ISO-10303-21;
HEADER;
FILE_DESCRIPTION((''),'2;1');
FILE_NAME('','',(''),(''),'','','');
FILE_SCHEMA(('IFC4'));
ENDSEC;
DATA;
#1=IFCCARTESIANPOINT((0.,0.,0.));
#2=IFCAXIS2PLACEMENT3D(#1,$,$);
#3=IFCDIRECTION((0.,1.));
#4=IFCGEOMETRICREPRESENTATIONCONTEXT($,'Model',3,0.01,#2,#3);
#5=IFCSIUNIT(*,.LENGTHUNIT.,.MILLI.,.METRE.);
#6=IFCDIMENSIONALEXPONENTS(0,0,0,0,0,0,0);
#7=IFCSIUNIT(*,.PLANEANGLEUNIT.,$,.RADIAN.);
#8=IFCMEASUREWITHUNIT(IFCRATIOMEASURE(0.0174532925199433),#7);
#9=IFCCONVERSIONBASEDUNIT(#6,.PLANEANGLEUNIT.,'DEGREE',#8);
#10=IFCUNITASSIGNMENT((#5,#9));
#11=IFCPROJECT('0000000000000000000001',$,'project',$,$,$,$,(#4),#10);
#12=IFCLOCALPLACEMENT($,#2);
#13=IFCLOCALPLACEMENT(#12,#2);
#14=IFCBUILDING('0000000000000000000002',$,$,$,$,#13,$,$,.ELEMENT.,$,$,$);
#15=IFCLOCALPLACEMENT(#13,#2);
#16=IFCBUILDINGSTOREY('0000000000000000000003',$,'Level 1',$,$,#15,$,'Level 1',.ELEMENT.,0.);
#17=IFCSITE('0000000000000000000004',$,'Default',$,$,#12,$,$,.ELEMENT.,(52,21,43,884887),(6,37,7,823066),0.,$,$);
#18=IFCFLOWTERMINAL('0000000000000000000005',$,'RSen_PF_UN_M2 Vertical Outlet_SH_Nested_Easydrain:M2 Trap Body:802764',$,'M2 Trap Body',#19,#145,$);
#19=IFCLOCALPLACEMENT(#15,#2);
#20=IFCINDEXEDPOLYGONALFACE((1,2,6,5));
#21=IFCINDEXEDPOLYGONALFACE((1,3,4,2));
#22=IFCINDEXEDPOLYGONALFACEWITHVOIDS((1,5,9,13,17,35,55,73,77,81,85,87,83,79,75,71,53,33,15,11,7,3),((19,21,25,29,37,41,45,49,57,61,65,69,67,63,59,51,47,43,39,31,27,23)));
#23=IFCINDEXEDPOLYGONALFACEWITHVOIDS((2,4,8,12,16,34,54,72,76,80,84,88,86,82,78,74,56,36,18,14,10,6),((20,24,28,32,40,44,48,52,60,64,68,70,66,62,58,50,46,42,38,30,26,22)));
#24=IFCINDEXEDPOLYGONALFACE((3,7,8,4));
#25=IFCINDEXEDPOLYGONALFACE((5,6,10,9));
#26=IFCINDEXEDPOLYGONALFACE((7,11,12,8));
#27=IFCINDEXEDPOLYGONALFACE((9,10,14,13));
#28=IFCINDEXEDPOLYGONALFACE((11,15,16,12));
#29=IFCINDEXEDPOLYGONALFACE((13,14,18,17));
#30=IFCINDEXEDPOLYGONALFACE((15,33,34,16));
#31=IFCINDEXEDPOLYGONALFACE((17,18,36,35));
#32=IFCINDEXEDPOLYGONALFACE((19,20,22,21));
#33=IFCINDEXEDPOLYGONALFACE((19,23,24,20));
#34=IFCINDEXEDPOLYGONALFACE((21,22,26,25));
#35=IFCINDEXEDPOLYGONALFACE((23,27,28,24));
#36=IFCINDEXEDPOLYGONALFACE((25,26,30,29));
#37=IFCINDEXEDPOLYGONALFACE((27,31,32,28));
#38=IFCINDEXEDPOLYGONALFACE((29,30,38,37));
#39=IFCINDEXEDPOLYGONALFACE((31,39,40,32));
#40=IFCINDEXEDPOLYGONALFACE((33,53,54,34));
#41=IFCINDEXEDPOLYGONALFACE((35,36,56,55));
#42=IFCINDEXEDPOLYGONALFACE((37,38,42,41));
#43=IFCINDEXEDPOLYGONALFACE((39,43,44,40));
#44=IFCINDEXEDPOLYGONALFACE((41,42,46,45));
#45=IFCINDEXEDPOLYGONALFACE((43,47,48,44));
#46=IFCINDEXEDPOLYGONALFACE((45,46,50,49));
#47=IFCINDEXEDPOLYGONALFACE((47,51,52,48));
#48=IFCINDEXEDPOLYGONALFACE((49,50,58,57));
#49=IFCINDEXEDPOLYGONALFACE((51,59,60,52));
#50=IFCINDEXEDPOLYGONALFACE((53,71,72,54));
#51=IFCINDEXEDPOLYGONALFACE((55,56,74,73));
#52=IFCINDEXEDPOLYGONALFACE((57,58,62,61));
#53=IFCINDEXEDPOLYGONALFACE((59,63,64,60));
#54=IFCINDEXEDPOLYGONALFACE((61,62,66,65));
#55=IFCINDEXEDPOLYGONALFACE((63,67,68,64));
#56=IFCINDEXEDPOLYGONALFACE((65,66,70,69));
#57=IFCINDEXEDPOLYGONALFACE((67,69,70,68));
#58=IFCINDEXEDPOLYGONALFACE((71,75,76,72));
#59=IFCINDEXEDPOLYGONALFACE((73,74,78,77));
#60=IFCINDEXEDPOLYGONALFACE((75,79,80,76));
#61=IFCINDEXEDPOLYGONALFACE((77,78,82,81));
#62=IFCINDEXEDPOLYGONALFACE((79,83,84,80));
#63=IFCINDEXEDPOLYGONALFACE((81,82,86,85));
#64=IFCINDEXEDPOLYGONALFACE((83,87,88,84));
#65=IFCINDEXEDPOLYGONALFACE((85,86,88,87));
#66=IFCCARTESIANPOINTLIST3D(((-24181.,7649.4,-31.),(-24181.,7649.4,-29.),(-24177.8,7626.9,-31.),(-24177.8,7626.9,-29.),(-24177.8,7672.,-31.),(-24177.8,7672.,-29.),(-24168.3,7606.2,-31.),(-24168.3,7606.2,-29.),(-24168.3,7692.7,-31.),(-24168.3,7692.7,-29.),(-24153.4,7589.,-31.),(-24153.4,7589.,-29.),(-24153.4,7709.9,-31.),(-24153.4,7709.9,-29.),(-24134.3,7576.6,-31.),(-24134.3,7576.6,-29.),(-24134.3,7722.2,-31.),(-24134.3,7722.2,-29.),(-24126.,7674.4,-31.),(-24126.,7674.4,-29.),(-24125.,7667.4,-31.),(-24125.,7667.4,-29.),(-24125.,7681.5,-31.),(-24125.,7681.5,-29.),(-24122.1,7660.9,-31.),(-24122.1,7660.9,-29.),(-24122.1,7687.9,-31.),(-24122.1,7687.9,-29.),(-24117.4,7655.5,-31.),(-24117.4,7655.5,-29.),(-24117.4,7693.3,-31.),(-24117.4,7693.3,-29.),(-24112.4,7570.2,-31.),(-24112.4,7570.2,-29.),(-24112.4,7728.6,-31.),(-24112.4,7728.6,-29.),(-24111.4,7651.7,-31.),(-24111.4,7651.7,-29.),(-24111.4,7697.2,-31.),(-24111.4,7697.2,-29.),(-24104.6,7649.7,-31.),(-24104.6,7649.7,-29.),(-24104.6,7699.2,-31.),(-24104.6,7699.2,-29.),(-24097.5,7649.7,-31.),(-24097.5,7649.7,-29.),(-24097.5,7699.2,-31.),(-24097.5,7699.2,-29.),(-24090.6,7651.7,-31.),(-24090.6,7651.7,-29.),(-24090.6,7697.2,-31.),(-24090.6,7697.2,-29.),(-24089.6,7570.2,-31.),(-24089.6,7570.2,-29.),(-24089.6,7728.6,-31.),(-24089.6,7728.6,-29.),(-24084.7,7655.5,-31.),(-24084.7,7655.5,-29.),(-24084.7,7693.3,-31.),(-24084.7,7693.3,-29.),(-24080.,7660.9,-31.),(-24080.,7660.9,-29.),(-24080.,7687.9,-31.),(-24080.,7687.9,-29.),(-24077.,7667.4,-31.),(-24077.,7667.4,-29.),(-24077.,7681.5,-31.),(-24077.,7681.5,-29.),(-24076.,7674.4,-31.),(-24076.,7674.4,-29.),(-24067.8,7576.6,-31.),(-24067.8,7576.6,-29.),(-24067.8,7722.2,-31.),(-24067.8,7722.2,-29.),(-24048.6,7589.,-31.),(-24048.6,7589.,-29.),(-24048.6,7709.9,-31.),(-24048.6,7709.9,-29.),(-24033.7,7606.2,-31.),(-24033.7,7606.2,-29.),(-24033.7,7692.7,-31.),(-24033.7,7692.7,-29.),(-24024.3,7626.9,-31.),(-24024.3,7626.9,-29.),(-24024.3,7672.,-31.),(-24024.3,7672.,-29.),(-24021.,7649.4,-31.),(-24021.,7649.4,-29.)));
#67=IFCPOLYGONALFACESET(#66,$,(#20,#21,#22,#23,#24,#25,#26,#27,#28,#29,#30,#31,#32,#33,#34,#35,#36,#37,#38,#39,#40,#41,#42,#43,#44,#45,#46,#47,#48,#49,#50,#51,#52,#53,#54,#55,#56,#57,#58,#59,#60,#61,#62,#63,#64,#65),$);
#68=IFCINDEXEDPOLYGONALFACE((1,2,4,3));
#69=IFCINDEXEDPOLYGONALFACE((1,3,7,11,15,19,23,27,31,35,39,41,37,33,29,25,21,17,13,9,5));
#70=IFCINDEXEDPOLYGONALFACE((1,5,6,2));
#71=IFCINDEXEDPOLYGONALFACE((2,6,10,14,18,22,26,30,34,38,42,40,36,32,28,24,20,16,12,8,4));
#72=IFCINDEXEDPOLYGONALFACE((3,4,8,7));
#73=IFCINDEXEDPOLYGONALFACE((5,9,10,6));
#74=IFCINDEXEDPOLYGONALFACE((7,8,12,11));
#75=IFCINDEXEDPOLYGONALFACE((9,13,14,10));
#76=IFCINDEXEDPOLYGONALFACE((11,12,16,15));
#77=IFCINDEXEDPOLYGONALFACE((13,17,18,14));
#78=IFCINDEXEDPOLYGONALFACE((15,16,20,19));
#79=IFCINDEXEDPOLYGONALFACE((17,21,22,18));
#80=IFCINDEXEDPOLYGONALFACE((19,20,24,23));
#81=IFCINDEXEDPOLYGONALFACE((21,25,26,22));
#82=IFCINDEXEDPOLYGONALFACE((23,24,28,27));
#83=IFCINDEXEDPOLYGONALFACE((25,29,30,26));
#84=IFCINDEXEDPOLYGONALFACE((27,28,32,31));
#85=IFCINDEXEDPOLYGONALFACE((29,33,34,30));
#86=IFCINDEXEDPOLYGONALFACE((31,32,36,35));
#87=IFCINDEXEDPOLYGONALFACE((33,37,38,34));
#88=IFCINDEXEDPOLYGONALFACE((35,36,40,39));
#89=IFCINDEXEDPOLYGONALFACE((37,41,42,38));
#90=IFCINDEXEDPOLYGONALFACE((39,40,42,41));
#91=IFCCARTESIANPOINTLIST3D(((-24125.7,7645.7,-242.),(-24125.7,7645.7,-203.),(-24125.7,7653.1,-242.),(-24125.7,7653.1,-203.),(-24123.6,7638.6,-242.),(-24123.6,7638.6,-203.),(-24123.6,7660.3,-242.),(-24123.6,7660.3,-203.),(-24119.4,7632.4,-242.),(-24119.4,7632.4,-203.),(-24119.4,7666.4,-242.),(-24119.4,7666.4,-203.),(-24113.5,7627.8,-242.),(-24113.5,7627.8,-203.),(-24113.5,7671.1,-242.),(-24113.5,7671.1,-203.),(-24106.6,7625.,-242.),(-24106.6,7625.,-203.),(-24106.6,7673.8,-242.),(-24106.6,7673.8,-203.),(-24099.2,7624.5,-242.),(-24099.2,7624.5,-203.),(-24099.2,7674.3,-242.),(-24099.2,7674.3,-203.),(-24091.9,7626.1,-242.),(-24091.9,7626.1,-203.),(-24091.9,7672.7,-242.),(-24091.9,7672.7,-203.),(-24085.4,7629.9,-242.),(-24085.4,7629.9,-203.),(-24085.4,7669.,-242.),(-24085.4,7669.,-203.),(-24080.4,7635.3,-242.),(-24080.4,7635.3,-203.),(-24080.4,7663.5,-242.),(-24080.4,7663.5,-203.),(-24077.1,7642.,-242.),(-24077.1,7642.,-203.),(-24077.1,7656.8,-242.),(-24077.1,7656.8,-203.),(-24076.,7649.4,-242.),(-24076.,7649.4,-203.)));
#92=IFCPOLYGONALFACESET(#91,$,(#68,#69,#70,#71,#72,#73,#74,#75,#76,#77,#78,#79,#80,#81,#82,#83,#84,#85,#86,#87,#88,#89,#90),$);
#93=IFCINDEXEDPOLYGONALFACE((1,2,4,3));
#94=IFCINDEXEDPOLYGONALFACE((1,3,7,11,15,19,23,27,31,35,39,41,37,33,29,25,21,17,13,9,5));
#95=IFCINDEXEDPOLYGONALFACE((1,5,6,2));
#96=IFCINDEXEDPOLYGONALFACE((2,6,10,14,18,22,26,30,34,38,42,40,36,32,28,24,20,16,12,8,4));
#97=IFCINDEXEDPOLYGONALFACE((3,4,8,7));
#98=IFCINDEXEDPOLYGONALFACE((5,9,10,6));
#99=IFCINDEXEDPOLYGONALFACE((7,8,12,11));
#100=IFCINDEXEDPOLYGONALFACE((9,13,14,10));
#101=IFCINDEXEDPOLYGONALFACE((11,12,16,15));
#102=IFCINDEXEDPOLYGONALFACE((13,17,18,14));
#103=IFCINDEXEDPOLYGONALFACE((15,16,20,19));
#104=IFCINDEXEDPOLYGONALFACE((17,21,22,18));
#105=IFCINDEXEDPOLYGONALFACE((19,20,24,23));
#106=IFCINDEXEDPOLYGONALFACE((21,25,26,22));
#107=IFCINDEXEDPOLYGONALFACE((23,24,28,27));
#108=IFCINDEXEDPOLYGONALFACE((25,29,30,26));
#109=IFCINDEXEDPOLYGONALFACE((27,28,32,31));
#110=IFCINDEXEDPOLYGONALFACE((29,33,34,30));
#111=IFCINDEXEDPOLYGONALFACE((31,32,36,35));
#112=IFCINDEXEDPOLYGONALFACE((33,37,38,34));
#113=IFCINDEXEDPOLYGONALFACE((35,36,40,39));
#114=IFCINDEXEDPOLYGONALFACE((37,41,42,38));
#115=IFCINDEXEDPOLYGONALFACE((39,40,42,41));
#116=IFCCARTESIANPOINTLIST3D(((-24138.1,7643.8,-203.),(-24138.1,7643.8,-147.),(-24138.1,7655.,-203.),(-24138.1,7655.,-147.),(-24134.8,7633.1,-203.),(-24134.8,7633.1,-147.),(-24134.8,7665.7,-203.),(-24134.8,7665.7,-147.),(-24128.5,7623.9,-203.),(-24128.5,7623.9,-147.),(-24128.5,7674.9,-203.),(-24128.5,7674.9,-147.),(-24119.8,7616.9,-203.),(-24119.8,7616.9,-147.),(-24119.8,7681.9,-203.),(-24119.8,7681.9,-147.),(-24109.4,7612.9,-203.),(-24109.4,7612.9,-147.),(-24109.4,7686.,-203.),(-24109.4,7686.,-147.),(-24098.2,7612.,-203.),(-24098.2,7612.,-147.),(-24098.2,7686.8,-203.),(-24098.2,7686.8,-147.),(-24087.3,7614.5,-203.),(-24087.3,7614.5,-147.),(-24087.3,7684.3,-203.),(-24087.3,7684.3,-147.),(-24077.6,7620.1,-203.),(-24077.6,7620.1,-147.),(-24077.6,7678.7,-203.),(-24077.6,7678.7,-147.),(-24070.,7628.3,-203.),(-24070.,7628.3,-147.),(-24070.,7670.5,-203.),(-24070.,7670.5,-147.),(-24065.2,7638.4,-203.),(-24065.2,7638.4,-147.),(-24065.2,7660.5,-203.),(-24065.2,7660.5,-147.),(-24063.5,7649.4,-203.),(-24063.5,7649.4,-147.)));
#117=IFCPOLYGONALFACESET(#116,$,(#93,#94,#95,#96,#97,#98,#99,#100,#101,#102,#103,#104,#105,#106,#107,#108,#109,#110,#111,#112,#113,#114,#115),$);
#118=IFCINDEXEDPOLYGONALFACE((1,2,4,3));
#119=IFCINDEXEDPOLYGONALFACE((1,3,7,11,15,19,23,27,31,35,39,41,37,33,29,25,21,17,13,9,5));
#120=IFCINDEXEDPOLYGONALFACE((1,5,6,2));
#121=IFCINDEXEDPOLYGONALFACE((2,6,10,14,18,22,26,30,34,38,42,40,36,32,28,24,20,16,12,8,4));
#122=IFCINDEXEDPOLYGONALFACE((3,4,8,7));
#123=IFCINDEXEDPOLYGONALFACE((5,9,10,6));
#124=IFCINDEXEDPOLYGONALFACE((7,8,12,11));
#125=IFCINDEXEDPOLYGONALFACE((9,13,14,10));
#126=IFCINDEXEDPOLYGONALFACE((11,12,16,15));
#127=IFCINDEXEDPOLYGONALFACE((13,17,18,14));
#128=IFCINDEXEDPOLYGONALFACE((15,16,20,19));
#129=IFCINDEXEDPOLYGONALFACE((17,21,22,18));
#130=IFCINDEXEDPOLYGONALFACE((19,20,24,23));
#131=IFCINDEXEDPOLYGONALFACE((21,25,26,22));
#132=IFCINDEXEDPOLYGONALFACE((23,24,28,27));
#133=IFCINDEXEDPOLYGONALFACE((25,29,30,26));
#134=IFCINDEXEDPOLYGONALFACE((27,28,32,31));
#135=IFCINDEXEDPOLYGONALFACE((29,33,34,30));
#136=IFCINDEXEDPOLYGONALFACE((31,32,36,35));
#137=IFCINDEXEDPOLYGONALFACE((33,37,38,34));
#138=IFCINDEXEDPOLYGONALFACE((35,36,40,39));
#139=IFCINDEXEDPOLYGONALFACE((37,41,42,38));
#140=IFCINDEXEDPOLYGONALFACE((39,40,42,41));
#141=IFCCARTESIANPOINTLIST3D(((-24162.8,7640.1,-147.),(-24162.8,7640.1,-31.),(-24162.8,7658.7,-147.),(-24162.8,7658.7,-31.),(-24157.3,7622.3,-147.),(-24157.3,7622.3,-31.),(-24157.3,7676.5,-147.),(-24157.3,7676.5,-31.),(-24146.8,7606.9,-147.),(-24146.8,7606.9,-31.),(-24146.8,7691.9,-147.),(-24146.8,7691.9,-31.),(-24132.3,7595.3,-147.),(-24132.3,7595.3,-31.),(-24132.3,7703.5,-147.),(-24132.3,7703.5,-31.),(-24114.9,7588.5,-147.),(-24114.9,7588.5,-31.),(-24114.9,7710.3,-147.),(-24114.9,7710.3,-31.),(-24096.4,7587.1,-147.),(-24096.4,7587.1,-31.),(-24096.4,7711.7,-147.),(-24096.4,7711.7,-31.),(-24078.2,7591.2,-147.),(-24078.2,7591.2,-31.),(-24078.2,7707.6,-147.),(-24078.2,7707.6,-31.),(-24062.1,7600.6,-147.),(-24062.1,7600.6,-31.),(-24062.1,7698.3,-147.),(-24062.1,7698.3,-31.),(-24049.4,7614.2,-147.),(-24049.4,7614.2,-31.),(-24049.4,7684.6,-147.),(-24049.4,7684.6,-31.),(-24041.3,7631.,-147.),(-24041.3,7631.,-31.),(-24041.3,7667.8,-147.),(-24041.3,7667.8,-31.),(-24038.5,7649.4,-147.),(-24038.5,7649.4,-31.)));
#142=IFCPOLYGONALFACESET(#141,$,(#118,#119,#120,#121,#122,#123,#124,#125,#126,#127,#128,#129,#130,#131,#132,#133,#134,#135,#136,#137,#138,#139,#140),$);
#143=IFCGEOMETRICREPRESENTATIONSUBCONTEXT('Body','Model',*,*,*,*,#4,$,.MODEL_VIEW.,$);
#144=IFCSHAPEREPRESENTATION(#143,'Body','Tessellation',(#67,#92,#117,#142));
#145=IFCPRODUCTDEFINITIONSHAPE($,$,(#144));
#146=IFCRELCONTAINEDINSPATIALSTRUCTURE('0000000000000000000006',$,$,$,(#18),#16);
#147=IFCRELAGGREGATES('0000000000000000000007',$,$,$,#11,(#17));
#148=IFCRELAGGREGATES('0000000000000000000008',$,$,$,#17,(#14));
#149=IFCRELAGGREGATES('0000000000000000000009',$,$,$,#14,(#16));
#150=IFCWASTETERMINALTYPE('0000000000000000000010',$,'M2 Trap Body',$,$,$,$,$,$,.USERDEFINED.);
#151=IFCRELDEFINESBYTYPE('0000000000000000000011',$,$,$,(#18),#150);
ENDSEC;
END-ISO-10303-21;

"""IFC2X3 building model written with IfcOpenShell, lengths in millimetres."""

from ifc_helpers import new_model, entity, si_unit, converted_unit, direction, frame, frame_2d, origin, origin_2d_with_axis, place, context, subcontext, project, spatial, circle_curve, parameter, trimmed, segment, composite_curve, circle, outline, extrude, source, transform, mapped, type_object, type_shapes, element, save


model = new_model("IFC2X3")

# Units and contexts
model_context = context("Model", 3, precision=0.01, world=origin(), true_north=direction((0.0, 1.0)))
body_context = subcontext(model_context, "Body", "Model", "MODEL_VIEW")
ifc_project = project(units=[si_unit("LENGTHUNIT", "METRE", prefix="MILLI"), converted_unit("PLANEANGLEUNIT", "DEGREE", entity("IfcRatioMeasure", 0.0174532925199433), si_unit("PLANEANGLEUNIT", "RADIAN"), dimensions=[0, 0, 0, 0, 0, 0, 0])], contexts=[model_context])

# Site, building, storey
site_placement = place(None, origin())
site = spatial("IfcSite", under=ifc_project, at=site_placement, Name="Default", CompositionType="ELEMENT", RefLatitude=(52, 21, 43, 884887), RefLongitude=(6, 37, 7, 823066), RefElevation=0.0)
building_placement = place(site_placement, origin())
building = spatial("IfcBuilding", under=site, at=building_placement, CompositionType="ELEMENT")
storey_placement = place(building_placement, origin())
storey = spatial("IfcBuildingStorey", under=building, at=storey_placement, Name="Level 1", LongName="Level 1", CompositionType="ELEMENT", Elevation=0.0)

# Flow terminal
waste_terminal_type_1 = type_object("IfcWasteTerminalType", Name="M2 Trap Body", PredefinedType="USERDEFINED")
shared_shape_1 = source(origin(), body_context, "Body", "SweptSolid", [
    extrude(outline(composite_curve([segment(trimmed(circle_curve(origin_2d_with_axis(), 80.0), [parameter(0.0)], [parameter(180.0)], True, "PARAMETER"), True, "CONTINUOUS"), segment(trimmed(circle_curve(origin_2d_with_axis(), 80.0), [parameter(180.0)], [parameter(360.0)], True, "PARAMETER"), True, "CONTINUOUS")], self_intersect=False), holes=[composite_curve([segment(trimmed(circle_curve(frame_2d((0.0, 25.0), x_axis=(1.0, 0.0)), 25.0), [parameter(180.0)], [parameter(360.0)], True, "PARAMETER"), False, "CONTINUOUS"), segment(trimmed(circle_curve(frame_2d((0.0, 25.0), x_axis=(1.0, 0.0)), 25.0), [parameter(0.0)], [parameter(180.0)], True, "PARAMETER"), False, "CONTINUOUS")], self_intersect=False)]), frame((0.0, -25.0, -2.0)), (0.0, 0.0, 1.0), 2.0),
    extrude(circle(Radius=25.0, at=frame_2d((0.0, 0.0), x_axis=(1.0, 0.0))), frame((0.0, -25.0, -213.0)), (0.0, 0.0, 1.0), 39.0),
    extrude(circle(Radius=37.5, at=frame_2d((0.0, 0.0), x_axis=(1.0, 0.0))), frame((0.0, -25.0, -174.0)), (0.0, 0.0, 1.0), 56.0),
    extrude(circle(Radius=62.5, at=frame_2d((0.0, 0.0), x_axis=(1.0, 0.0))), frame((0.0, -25.0, -118.0)), (0.0, 0.0, 1.0), 116.0),
])
type_shapes(waste_terminal_type_1, [shared_shape_1])
for number, where, name in (
    (1, (-24101.0, 7674.4, -29.0), "RSen_PF_UN_M2 Vertical Outlet_SH_Nested_Easydrain:M2 Trap Body:802764"),
):
    element("IfcFlowTerminal", number, at=place(storey_placement, frame(where)), inside=storey, type_object=waste_terminal_type_1, Name=name, ObjectType="M2 Trap Body", context=body_context, shape_type="MappedRepresentation", body=[
        mapped(shared_shape_1, transform((0.0, 0.0, 0.0), scale=1.0)),
    ])

save(model, "model.ifc")
